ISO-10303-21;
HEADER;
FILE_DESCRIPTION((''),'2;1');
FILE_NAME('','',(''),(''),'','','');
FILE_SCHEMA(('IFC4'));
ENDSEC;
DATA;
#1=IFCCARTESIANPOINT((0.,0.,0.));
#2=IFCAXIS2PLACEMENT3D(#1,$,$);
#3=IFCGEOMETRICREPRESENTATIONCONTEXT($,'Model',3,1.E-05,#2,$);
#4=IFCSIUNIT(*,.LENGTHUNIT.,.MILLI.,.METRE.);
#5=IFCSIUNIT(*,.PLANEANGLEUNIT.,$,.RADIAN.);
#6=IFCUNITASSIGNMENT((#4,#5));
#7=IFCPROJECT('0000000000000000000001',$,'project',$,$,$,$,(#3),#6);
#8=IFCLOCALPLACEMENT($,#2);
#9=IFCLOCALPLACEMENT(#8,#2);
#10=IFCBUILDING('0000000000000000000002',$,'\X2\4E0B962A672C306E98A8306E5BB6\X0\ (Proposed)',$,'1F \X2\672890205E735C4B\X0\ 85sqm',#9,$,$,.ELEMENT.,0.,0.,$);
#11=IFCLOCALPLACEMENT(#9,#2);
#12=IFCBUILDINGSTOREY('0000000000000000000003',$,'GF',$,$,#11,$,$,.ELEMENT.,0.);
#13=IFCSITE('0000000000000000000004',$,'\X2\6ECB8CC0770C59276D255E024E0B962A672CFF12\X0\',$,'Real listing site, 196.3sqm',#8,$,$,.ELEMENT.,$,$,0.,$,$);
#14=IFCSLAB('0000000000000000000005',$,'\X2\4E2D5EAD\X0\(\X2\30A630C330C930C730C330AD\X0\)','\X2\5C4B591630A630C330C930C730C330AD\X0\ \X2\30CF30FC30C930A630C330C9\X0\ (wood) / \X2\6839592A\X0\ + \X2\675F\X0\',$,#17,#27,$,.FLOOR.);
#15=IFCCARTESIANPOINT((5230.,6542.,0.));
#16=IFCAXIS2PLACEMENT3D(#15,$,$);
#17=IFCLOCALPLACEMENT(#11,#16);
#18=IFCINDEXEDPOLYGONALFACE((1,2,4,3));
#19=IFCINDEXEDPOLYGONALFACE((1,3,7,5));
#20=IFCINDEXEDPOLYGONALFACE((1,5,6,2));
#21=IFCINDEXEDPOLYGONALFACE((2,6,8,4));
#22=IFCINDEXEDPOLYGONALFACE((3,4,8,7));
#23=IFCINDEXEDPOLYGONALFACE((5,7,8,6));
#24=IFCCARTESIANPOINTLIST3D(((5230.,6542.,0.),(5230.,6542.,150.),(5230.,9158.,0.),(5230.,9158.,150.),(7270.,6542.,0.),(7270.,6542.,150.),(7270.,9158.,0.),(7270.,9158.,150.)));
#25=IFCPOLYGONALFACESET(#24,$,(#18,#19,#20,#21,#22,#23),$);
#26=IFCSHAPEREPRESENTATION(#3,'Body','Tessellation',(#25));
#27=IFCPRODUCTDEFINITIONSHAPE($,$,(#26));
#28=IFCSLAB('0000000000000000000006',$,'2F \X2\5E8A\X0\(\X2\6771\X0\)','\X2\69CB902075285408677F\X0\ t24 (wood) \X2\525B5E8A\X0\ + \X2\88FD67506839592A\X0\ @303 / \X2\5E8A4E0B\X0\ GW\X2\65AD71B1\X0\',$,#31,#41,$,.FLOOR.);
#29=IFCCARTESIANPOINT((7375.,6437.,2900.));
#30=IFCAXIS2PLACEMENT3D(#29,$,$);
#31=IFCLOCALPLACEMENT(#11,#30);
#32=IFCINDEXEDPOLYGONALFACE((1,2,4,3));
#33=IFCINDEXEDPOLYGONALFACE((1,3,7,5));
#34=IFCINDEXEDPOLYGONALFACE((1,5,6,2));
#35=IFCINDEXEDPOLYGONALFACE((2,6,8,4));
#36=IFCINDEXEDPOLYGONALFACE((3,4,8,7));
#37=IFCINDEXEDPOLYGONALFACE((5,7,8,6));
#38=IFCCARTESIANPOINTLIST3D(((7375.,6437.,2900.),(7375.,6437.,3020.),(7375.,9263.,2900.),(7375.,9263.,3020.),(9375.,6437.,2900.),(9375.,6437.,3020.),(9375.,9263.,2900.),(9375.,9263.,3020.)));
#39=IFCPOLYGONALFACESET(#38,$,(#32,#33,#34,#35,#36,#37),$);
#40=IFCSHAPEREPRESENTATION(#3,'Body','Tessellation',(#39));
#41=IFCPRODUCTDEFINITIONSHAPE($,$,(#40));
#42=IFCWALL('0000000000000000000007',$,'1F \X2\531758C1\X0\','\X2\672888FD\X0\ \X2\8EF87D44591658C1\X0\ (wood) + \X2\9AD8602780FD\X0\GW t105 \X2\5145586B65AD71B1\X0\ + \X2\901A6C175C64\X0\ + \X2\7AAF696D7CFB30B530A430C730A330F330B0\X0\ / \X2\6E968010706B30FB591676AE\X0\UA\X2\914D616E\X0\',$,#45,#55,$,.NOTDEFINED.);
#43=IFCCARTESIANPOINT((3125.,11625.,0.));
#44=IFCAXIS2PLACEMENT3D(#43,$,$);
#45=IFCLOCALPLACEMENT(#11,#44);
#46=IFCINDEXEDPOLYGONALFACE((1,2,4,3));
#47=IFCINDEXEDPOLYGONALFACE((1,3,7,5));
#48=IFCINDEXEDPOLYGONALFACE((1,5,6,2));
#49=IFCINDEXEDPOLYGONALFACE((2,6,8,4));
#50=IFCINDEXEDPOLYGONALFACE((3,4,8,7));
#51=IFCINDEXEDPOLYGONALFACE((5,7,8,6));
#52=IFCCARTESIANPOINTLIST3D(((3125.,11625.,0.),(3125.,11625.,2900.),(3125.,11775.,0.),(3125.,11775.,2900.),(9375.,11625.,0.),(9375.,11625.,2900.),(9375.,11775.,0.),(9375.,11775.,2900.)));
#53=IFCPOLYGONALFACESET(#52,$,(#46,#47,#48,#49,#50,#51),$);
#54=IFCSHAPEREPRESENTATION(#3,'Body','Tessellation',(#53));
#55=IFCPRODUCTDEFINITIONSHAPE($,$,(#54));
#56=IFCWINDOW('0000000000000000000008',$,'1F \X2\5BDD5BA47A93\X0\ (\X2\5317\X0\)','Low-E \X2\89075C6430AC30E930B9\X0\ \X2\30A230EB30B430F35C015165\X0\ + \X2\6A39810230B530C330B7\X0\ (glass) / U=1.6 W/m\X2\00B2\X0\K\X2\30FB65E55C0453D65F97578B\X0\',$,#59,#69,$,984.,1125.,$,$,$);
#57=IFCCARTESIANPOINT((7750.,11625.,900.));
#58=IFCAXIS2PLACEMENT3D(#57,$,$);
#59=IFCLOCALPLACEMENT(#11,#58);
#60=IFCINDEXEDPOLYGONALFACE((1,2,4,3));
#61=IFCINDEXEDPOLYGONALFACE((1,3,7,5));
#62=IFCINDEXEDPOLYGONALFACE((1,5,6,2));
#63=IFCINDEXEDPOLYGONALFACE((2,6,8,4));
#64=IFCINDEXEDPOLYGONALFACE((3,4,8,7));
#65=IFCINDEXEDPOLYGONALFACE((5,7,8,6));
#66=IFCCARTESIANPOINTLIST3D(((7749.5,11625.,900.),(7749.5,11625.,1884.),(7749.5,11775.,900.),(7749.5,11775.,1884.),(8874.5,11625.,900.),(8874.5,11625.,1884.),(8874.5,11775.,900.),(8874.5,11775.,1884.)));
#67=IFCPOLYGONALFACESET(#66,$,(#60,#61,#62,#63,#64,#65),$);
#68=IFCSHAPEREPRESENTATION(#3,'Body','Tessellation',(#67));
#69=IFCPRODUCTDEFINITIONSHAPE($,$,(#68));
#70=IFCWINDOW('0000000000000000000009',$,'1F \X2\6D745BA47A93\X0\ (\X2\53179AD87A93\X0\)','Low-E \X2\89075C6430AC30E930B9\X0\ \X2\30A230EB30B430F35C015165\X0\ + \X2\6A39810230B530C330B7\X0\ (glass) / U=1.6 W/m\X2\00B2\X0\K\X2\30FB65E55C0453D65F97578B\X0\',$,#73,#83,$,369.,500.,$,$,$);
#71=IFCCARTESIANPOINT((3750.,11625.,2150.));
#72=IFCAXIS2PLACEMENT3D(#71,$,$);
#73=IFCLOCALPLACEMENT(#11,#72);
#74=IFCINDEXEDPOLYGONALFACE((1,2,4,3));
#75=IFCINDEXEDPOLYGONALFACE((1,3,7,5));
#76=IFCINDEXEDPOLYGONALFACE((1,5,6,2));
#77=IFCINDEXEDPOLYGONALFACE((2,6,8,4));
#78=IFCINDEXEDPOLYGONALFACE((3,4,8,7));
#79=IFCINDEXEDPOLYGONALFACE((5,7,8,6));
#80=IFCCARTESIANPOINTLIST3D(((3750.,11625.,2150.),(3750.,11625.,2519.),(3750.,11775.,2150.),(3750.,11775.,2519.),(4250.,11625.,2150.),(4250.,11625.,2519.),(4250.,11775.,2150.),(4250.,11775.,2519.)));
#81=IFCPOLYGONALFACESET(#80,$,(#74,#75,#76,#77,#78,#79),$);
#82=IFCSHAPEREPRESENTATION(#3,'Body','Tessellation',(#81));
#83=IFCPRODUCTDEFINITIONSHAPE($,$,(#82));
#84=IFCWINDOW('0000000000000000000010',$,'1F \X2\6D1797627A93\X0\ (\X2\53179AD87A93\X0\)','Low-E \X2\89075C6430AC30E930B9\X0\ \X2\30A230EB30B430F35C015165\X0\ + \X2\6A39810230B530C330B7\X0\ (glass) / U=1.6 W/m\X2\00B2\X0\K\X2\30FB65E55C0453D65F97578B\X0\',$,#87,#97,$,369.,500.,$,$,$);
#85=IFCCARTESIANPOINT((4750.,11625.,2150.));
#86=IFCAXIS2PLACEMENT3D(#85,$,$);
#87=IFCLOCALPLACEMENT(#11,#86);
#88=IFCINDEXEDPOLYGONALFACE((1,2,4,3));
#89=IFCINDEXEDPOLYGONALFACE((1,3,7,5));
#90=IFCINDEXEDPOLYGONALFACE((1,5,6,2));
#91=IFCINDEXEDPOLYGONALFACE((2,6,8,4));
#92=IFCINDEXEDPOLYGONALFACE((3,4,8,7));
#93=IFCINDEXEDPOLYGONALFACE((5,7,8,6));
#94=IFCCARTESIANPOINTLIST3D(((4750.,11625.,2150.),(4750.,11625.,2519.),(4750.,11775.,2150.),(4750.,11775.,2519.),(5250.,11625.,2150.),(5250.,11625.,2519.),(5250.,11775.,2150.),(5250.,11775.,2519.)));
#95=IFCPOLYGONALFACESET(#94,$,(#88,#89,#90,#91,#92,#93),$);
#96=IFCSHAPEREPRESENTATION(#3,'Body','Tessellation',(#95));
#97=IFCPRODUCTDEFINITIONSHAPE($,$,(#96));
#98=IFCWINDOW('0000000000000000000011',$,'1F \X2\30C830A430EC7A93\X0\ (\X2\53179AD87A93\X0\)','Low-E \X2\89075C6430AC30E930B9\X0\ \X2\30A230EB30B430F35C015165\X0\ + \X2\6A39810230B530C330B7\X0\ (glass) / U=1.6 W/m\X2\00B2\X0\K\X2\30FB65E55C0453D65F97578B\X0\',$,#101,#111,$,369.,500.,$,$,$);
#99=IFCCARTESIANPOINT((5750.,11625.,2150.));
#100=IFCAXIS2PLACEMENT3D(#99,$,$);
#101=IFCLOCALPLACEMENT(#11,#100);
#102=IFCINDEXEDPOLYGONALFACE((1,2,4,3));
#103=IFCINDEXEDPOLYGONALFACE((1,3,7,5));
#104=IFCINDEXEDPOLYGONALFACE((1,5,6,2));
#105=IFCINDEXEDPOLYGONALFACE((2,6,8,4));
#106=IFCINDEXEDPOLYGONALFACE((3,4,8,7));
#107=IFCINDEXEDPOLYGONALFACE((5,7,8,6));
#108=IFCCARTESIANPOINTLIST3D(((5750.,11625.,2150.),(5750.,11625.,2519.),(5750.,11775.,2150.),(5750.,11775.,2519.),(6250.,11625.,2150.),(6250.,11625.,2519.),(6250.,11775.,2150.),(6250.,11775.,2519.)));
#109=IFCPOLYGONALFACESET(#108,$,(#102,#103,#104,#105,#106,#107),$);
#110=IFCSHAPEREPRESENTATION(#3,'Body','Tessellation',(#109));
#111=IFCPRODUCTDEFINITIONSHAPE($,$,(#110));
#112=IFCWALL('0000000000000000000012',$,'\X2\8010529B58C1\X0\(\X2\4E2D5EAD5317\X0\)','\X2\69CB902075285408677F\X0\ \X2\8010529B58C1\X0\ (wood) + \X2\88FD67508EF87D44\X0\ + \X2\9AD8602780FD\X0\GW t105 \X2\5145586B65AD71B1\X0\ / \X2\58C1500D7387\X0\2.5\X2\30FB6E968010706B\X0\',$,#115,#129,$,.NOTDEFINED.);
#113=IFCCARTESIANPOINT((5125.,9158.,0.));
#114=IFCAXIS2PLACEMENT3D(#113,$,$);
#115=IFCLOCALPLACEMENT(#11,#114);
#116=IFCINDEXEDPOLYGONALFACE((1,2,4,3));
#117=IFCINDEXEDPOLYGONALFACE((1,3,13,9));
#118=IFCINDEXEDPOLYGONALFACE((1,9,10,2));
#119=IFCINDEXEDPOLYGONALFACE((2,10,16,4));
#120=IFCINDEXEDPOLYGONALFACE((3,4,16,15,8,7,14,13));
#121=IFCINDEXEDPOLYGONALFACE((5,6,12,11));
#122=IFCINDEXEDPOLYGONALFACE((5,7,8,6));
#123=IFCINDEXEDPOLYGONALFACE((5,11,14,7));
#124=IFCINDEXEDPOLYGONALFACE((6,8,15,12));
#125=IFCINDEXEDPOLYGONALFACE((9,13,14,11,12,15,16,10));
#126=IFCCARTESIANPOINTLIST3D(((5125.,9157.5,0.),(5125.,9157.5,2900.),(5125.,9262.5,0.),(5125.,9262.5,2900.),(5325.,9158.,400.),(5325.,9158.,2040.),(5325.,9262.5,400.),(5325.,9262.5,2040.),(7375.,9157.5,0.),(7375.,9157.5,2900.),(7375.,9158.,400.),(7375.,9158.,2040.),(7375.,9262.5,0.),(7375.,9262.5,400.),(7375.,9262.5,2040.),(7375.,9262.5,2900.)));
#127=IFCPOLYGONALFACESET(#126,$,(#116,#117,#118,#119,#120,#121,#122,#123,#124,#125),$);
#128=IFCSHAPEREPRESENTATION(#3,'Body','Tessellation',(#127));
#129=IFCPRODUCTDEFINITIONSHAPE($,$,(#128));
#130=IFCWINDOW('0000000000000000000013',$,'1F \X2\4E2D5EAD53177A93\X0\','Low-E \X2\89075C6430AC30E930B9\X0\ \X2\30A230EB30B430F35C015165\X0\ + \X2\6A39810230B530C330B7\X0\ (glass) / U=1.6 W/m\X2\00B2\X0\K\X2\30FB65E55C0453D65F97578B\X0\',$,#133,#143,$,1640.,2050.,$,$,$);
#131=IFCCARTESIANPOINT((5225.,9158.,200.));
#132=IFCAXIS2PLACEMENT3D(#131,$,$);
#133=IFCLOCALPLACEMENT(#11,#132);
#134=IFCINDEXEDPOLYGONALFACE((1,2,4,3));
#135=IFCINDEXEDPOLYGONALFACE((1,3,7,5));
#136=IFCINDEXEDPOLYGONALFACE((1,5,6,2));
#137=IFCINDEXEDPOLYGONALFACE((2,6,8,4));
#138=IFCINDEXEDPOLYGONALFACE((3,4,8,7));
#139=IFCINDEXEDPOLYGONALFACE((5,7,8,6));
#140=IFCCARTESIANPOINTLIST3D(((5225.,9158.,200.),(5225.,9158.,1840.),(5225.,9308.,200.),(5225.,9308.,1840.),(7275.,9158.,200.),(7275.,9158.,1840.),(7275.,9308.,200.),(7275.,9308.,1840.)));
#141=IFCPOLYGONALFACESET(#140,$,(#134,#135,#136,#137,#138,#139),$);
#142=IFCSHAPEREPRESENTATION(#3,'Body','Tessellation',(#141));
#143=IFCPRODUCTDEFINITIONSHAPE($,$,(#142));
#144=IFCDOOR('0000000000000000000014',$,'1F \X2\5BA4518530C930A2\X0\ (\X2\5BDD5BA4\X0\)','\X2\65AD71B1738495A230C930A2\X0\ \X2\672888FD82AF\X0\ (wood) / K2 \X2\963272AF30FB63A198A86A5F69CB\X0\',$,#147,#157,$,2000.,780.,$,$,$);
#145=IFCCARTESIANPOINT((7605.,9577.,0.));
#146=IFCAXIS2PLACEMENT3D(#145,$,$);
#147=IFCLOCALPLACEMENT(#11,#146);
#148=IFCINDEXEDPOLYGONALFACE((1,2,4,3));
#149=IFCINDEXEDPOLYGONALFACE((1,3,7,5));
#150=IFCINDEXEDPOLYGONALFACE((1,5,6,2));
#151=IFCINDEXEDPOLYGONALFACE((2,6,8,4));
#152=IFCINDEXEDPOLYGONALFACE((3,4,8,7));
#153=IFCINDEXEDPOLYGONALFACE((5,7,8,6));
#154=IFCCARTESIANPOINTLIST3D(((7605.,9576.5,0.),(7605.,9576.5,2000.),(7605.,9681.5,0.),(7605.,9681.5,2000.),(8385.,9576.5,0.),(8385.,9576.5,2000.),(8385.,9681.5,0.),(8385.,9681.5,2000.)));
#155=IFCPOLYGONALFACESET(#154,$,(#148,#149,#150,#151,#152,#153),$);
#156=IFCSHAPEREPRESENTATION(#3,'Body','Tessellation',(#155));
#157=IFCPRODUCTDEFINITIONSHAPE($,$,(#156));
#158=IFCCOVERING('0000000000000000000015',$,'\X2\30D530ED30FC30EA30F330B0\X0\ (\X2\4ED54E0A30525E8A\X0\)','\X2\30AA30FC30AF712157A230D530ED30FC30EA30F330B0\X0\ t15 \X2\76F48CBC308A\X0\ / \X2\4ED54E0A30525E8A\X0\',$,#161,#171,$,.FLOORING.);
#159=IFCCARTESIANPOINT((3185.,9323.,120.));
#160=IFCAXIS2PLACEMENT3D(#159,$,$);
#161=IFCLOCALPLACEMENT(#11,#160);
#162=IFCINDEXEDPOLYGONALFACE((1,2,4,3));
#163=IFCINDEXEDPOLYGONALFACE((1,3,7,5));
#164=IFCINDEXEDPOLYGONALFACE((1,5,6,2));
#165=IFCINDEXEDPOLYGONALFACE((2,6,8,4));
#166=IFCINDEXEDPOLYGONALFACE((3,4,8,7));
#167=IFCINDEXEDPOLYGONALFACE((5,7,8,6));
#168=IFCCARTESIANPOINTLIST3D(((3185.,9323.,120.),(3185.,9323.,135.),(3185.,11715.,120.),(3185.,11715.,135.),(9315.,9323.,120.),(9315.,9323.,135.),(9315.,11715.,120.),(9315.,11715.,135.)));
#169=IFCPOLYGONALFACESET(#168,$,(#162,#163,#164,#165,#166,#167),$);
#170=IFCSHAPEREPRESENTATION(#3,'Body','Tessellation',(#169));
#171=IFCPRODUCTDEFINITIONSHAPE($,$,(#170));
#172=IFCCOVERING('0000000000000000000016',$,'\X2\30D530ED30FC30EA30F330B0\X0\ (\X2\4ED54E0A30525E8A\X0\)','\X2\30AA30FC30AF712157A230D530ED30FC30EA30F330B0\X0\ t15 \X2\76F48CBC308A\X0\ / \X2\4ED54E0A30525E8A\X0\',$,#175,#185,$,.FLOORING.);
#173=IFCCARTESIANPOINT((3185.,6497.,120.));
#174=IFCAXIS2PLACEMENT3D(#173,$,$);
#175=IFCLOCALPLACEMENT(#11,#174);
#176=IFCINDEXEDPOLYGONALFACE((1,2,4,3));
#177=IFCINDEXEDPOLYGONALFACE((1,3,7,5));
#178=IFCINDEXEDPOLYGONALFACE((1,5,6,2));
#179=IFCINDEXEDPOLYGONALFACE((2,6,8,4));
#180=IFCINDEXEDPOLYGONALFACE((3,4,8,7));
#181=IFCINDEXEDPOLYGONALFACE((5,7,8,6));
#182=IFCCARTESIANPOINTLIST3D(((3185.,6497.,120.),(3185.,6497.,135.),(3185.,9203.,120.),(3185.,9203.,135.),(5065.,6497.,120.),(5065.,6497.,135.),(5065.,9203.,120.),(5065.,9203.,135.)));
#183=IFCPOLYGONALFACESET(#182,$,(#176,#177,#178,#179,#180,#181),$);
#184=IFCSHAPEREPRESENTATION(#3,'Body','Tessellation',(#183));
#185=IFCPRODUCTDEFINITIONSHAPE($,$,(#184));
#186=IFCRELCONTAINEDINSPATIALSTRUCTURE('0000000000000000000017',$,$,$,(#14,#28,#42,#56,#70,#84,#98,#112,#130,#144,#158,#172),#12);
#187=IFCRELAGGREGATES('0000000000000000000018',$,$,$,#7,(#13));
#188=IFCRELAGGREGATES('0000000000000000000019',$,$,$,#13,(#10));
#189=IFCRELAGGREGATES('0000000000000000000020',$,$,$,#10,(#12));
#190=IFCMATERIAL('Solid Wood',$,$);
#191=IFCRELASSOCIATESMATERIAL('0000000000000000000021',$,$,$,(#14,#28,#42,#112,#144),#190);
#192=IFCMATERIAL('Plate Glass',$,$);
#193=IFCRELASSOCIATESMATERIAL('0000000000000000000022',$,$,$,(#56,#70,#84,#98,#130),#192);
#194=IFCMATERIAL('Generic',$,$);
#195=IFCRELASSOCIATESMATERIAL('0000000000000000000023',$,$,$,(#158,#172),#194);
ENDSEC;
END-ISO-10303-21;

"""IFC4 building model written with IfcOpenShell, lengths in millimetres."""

from ifc_helpers import new_model, si_unit, frame, frame_2d, origin, place, context, project, spatial, rectangle, extrude, material, element, fill, save


model = new_model("IFC4")

# Units and contexts
model_context = context("Model", 3, precision=1e-05, world=origin())
ifc_project = project(units=[si_unit("LENGTHUNIT", "METRE", prefix="MILLI"), si_unit("PLANEANGLEUNIT", "RADIAN")], contexts=[model_context])

# Site, building, storey
site_placement = place(None, origin())
site = spatial("IfcSite", under=ifc_project, at=site_placement, Name="滋賀県大津市下阪本２", ObjectType="Real listing site, 196.3sqm", CompositionType="ELEMENT", RefElevation=0.0)
building_placement = place(site_placement, origin())
building = spatial("IfcBuilding", under=site, at=building_placement, Name="下阪本の風の家 (Proposed)", ObjectType="1F 木造平屋 85sqm", CompositionType="ELEMENT", ElevationOfRefHeight=0.0, ElevationOfTerrain=0.0)
storey_placement = place(building_placement, origin())
storey = spatial("IfcBuildingStorey", under=building, at=storey_placement, Name="GF", CompositionType="ELEMENT", Elevation=0.0)

# Slabs
ifc_material_1 = material(Name="Solid Wood")
slab_1_placement = place(storey_placement, frame((5230.0, 6542.0, 0.0)))
element("IfcSlab", 1, at=slab_1_placement, inside=storey, material=ifc_material_1, Name="中庭(ウッドデッキ)", Description="屋外ウッドデッキ ハードウッド (wood) / 根太 + 束", PredefinedType="FLOOR", context=model_context, shape_type="SweptSolid", body=[
    extrude(rectangle(XDim=2040.0, YDim=2616.0, at=frame_2d((1020.0, 1308.0))), frame((5230.0, 6542.0, 0.0)), (0.0, 0.0, 1.0), 150.0),
])
slab_2_placement = place(storey_placement, frame((7375.0, 6437.0, 2900.0)))
element("IfcSlab", 2, at=slab_2_placement, inside=storey, material=ifc_material_1, Name="2F 床(東)", Description="構造用合板 t24 (wood) 剛床 + 製材根太 @303 / 床下 GW断熱", PredefinedType="FLOOR", context=model_context, shape_type="SweptSolid", body=[
    extrude(rectangle(XDim=2000.0, YDim=2826.0, at=frame_2d((1000.0, 1413.0))), frame((7375.0, 6437.0, 2900.0)), (0.0, 0.0, 1.0), 120.0),
])

# Wall, openings, windows
wall_1_placement = place(storey_placement, frame((3125.0, 11625.0, 0.0)))
wall_1 = element("IfcWall", 3, at=wall_1_placement, inside=storey, material=ifc_material_1, Name="1F 北壁", Description="木製 軸組外壁 (wood) + 高性能GW t105 充填断熱 + 通気層 + 窯業系サイディング / 準耐火・外皮UA配慮", PredefinedType="NOTDEFINED", context=model_context, shape_type="SweptSolid", body=[
    extrude(rectangle(XDim=6250.0, YDim=150.0, at=frame_2d((3125.0, 75.0))), frame((3125.0, 11625.0, 0.0)), (0.0, 0.0, 1.0), 2900.0),
])
opening_1_placement = place(storey_placement, frame((7750.0, 11625.0, 900.0)))
opening_1 = element("IfcOpeningElement", 4, at=opening_1_placement, cuts=wall_1, PredefinedType="NOTDEFINED", context=model_context, shape_type="SweptSolid", body=[
    extrude(rectangle(XDim=1125.0, YDim=150.0, at=frame_2d((562.0, 75.0))), frame((7750.0, 11625.0, 900.0)), (0.0, 0.0, 1.0), 984.0),
])
opening_2_placement = place(storey_placement, frame((3750.0, 11625.0, 2150.0)))
opening_2 = element("IfcOpeningElement", 5, at=opening_2_placement, cuts=wall_1, PredefinedType="NOTDEFINED", context=model_context, shape_type="SweptSolid", body=[
    extrude(rectangle(XDim=500.0, YDim=150.0, at=frame_2d((250.0, 75.0))), frame((3750.0, 11625.0, 2150.0)), (0.0, 0.0, 1.0), 369.0),
])
opening_3_placement = place(storey_placement, frame((4750.0, 11625.0, 2150.0)))
opening_3 = element("IfcOpeningElement", 6, at=opening_3_placement, cuts=wall_1, PredefinedType="NOTDEFINED", context=model_context, shape_type="SweptSolid", body=[
    extrude(rectangle(XDim=500.0, YDim=150.0, at=frame_2d((250.0, 75.0))), frame((4750.0, 11625.0, 2150.0)), (0.0, 0.0, 1.0), 369.0),
])
opening_4_placement = place(storey_placement, frame((5750.0, 11625.0, 2150.0)))
opening_4 = element("IfcOpeningElement", 7, at=opening_4_placement, cuts=wall_1, PredefinedType="NOTDEFINED", context=model_context, shape_type="SweptSolid", body=[
    extrude(rectangle(XDim=500.0, YDim=150.0, at=frame_2d((250.0, 75.0))), frame((5750.0, 11625.0, 2150.0)), (0.0, 0.0, 1.0), 369.0),
])
ifc_material_2 = material(Name="Plate Glass")
window_1_placement = place(storey_placement, frame((7750.0, 11625.0, 900.0)))
window_1 = element("IfcWindow", 8, at=window_1_placement, inside=storey, material=ifc_material_2, Name="1F 寝室窓 (北)", Description="Low-E 複層ガラス アルゴン封入 + 樹脂サッシ (glass) / U=1.6 W/m²K・日射取得型", OverallHeight=984.0, OverallWidth=1125.0, context=model_context, shape_type="SweptSolid", body=[
    extrude(rectangle(XDim=1125.0, YDim=150.0, at=frame_2d((562.0, 75.0))), frame((7750.0, 11625.0, 900.0)), (0.0, 0.0, 1.0), 984.0),
])
fill(opening_1, window_1)
window_2_placement = place(storey_placement, frame((3750.0, 11625.0, 2150.0)))
window_2 = element("IfcWindow", 9, at=window_2_placement, inside=storey, material=ifc_material_2, Name="1F 浴室窓 (北高窓)", Description="Low-E 複層ガラス アルゴン封入 + 樹脂サッシ (glass) / U=1.6 W/m²K・日射取得型", OverallHeight=369.0, OverallWidth=500.0, context=model_context, shape_type="SweptSolid", body=[
    extrude(rectangle(XDim=500.0, YDim=150.0, at=frame_2d((250.0, 75.0))), frame((3750.0, 11625.0, 2150.0)), (0.0, 0.0, 1.0), 369.0),
])
fill(opening_2, window_2)
window_3_placement = place(storey_placement, frame((4750.0, 11625.0, 2150.0)))
window_3 = element("IfcWindow", 10, at=window_3_placement, inside=storey, material=ifc_material_2, Name="1F 洗面窓 (北高窓)", Description="Low-E 複層ガラス アルゴン封入 + 樹脂サッシ (glass) / U=1.6 W/m²K・日射取得型", OverallHeight=369.0, OverallWidth=500.0, context=model_context, shape_type="SweptSolid", body=[
    extrude(rectangle(XDim=500.0, YDim=150.0, at=frame_2d((250.0, 75.0))), frame((4750.0, 11625.0, 2150.0)), (0.0, 0.0, 1.0), 369.0),
])
fill(opening_3, window_3)
window_4_placement = place(storey_placement, frame((5750.0, 11625.0, 2150.0)))
window_4 = element("IfcWindow", 11, at=window_4_placement, inside=storey, material=ifc_material_2, Name="1F トイレ窓 (北高窓)", Description="Low-E 複層ガラス アルゴン封入 + 樹脂サッシ (glass) / U=1.6 W/m²K・日射取得型", OverallHeight=369.0, OverallWidth=500.0, context=model_context, shape_type="SweptSolid", body=[
    extrude(rectangle(XDim=500.0, YDim=150.0, at=frame_2d((250.0, 75.0))), frame((5750.0, 11625.0, 2150.0)), (0.0, 0.0, 1.0), 369.0),
])
fill(opening_4, window_4)

# Wall, opening, window
wall_2_placement = place(storey_placement, frame((5125.0, 9158.0, 0.0)))
wall_2 = element("IfcWall", 12, at=wall_2_placement, inside=storey, material=ifc_material_1, Name="耐力壁(中庭北)", Description="構造用合板 耐力壁 (wood) + 製材軸組 + 高性能GW t105 充填断熱 / 壁倍率2.5・準耐火", PredefinedType="NOTDEFINED", context=model_context, shape_type="SweptSolid", body=[
    extrude(rectangle(XDim=2250.0, YDim=105.0, at=frame_2d((1125.0, 52.0))), frame((5125.0, 9158.0, 0.0)), (0.0, 0.0, 1.0), 2900.0),
])
opening_5_placement = place(storey_placement, frame((5225.0, 9158.0, 200.0)))
opening_5 = element("IfcOpeningElement", 13, at=opening_5_placement, cuts=wall_2, PredefinedType="NOTDEFINED", context=model_context, shape_type="SweptSolid", body=[
    extrude(rectangle(XDim=2050.0, YDim=150.0, at=frame_2d((1025.0, 75.0))), frame((5225.0, 9158.0, 200.0)), (0.0, 0.0, 1.0), 1640.0),
])
window_5_placement = place(storey_placement, frame((5225.0, 9158.0, 200.0)))
window_5 = element("IfcWindow", 14, at=window_5_placement, inside=storey, material=ifc_material_2, Name="1F 中庭北窓", Description="Low-E 複層ガラス アルゴン封入 + 樹脂サッシ (glass) / U=1.6 W/m²K・日射取得型", OverallHeight=1640.0, OverallWidth=2050.0, context=model_context, shape_type="SweptSolid", body=[
    extrude(rectangle(XDim=2050.0, YDim=150.0, at=frame_2d((1025.0, 75.0))), frame((5225.0, 9158.0, 200.0)), (0.0, 0.0, 1.0), 1640.0),
])
fill(opening_5, window_5)

# Door
door_1_placement = place(storey_placement, frame((7605.0, 9577.0, 0.0)))
element("IfcDoor", 15, at=door_1_placement, inside=storey, material=ifc_material_1, Name="1F 室内ドア (寝室)", Description="断熱玄関ドア 木製芯 (wood) / K2 防犯・採風機構", OverallHeight=2000.0, OverallWidth=780.0, context=model_context, shape_type="SweptSolid", body=[
    extrude(rectangle(XDim=780.0, YDim=105.0, at=frame_2d((390.0, 52.0))), frame((7605.0, 9577.0, 0.0)), (0.0, 0.0, 1.0), 2000.0),
])

# Coverings
ifc_material_3 = material(Name="Generic")
covering_1_placement = place(storey_placement, frame((3185.0, 9323.0, 120.0)))
element("IfcCovering", 16, at=covering_1_placement, inside=storey, material=ifc_material_3, Name="フローリング (仕上げ床)", Description="オーク無垢フローリング t15 直貼り / 仕上げ床", PredefinedType="FLOORING", context=model_context, shape_type="SweptSolid", body=[
    extrude(rectangle(XDim=6130.0, YDim=2392.0, at=frame_2d((3065.0, 1196.0))), frame((3185.0, 9323.0, 120.0)), (0.0, 0.0, 1.0), 15.0),
])
covering_2_placement = place(storey_placement, frame((3185.0, 6497.0, 120.0)))
element("IfcCovering", 17, at=covering_2_placement, inside=storey, material=ifc_material_3, Name="フローリング (仕上げ床)", Description="オーク無垢フローリング t15 直貼り / 仕上げ床", PredefinedType="FLOORING", context=model_context, shape_type="SweptSolid", body=[
    extrude(rectangle(XDim=1880.0, YDim=2706.0, at=frame_2d((940.0, 1353.0))), frame((3185.0, 6497.0, 120.0)), (0.0, 0.0, 1.0), 15.0),
])

save(model, "model.ifc")
